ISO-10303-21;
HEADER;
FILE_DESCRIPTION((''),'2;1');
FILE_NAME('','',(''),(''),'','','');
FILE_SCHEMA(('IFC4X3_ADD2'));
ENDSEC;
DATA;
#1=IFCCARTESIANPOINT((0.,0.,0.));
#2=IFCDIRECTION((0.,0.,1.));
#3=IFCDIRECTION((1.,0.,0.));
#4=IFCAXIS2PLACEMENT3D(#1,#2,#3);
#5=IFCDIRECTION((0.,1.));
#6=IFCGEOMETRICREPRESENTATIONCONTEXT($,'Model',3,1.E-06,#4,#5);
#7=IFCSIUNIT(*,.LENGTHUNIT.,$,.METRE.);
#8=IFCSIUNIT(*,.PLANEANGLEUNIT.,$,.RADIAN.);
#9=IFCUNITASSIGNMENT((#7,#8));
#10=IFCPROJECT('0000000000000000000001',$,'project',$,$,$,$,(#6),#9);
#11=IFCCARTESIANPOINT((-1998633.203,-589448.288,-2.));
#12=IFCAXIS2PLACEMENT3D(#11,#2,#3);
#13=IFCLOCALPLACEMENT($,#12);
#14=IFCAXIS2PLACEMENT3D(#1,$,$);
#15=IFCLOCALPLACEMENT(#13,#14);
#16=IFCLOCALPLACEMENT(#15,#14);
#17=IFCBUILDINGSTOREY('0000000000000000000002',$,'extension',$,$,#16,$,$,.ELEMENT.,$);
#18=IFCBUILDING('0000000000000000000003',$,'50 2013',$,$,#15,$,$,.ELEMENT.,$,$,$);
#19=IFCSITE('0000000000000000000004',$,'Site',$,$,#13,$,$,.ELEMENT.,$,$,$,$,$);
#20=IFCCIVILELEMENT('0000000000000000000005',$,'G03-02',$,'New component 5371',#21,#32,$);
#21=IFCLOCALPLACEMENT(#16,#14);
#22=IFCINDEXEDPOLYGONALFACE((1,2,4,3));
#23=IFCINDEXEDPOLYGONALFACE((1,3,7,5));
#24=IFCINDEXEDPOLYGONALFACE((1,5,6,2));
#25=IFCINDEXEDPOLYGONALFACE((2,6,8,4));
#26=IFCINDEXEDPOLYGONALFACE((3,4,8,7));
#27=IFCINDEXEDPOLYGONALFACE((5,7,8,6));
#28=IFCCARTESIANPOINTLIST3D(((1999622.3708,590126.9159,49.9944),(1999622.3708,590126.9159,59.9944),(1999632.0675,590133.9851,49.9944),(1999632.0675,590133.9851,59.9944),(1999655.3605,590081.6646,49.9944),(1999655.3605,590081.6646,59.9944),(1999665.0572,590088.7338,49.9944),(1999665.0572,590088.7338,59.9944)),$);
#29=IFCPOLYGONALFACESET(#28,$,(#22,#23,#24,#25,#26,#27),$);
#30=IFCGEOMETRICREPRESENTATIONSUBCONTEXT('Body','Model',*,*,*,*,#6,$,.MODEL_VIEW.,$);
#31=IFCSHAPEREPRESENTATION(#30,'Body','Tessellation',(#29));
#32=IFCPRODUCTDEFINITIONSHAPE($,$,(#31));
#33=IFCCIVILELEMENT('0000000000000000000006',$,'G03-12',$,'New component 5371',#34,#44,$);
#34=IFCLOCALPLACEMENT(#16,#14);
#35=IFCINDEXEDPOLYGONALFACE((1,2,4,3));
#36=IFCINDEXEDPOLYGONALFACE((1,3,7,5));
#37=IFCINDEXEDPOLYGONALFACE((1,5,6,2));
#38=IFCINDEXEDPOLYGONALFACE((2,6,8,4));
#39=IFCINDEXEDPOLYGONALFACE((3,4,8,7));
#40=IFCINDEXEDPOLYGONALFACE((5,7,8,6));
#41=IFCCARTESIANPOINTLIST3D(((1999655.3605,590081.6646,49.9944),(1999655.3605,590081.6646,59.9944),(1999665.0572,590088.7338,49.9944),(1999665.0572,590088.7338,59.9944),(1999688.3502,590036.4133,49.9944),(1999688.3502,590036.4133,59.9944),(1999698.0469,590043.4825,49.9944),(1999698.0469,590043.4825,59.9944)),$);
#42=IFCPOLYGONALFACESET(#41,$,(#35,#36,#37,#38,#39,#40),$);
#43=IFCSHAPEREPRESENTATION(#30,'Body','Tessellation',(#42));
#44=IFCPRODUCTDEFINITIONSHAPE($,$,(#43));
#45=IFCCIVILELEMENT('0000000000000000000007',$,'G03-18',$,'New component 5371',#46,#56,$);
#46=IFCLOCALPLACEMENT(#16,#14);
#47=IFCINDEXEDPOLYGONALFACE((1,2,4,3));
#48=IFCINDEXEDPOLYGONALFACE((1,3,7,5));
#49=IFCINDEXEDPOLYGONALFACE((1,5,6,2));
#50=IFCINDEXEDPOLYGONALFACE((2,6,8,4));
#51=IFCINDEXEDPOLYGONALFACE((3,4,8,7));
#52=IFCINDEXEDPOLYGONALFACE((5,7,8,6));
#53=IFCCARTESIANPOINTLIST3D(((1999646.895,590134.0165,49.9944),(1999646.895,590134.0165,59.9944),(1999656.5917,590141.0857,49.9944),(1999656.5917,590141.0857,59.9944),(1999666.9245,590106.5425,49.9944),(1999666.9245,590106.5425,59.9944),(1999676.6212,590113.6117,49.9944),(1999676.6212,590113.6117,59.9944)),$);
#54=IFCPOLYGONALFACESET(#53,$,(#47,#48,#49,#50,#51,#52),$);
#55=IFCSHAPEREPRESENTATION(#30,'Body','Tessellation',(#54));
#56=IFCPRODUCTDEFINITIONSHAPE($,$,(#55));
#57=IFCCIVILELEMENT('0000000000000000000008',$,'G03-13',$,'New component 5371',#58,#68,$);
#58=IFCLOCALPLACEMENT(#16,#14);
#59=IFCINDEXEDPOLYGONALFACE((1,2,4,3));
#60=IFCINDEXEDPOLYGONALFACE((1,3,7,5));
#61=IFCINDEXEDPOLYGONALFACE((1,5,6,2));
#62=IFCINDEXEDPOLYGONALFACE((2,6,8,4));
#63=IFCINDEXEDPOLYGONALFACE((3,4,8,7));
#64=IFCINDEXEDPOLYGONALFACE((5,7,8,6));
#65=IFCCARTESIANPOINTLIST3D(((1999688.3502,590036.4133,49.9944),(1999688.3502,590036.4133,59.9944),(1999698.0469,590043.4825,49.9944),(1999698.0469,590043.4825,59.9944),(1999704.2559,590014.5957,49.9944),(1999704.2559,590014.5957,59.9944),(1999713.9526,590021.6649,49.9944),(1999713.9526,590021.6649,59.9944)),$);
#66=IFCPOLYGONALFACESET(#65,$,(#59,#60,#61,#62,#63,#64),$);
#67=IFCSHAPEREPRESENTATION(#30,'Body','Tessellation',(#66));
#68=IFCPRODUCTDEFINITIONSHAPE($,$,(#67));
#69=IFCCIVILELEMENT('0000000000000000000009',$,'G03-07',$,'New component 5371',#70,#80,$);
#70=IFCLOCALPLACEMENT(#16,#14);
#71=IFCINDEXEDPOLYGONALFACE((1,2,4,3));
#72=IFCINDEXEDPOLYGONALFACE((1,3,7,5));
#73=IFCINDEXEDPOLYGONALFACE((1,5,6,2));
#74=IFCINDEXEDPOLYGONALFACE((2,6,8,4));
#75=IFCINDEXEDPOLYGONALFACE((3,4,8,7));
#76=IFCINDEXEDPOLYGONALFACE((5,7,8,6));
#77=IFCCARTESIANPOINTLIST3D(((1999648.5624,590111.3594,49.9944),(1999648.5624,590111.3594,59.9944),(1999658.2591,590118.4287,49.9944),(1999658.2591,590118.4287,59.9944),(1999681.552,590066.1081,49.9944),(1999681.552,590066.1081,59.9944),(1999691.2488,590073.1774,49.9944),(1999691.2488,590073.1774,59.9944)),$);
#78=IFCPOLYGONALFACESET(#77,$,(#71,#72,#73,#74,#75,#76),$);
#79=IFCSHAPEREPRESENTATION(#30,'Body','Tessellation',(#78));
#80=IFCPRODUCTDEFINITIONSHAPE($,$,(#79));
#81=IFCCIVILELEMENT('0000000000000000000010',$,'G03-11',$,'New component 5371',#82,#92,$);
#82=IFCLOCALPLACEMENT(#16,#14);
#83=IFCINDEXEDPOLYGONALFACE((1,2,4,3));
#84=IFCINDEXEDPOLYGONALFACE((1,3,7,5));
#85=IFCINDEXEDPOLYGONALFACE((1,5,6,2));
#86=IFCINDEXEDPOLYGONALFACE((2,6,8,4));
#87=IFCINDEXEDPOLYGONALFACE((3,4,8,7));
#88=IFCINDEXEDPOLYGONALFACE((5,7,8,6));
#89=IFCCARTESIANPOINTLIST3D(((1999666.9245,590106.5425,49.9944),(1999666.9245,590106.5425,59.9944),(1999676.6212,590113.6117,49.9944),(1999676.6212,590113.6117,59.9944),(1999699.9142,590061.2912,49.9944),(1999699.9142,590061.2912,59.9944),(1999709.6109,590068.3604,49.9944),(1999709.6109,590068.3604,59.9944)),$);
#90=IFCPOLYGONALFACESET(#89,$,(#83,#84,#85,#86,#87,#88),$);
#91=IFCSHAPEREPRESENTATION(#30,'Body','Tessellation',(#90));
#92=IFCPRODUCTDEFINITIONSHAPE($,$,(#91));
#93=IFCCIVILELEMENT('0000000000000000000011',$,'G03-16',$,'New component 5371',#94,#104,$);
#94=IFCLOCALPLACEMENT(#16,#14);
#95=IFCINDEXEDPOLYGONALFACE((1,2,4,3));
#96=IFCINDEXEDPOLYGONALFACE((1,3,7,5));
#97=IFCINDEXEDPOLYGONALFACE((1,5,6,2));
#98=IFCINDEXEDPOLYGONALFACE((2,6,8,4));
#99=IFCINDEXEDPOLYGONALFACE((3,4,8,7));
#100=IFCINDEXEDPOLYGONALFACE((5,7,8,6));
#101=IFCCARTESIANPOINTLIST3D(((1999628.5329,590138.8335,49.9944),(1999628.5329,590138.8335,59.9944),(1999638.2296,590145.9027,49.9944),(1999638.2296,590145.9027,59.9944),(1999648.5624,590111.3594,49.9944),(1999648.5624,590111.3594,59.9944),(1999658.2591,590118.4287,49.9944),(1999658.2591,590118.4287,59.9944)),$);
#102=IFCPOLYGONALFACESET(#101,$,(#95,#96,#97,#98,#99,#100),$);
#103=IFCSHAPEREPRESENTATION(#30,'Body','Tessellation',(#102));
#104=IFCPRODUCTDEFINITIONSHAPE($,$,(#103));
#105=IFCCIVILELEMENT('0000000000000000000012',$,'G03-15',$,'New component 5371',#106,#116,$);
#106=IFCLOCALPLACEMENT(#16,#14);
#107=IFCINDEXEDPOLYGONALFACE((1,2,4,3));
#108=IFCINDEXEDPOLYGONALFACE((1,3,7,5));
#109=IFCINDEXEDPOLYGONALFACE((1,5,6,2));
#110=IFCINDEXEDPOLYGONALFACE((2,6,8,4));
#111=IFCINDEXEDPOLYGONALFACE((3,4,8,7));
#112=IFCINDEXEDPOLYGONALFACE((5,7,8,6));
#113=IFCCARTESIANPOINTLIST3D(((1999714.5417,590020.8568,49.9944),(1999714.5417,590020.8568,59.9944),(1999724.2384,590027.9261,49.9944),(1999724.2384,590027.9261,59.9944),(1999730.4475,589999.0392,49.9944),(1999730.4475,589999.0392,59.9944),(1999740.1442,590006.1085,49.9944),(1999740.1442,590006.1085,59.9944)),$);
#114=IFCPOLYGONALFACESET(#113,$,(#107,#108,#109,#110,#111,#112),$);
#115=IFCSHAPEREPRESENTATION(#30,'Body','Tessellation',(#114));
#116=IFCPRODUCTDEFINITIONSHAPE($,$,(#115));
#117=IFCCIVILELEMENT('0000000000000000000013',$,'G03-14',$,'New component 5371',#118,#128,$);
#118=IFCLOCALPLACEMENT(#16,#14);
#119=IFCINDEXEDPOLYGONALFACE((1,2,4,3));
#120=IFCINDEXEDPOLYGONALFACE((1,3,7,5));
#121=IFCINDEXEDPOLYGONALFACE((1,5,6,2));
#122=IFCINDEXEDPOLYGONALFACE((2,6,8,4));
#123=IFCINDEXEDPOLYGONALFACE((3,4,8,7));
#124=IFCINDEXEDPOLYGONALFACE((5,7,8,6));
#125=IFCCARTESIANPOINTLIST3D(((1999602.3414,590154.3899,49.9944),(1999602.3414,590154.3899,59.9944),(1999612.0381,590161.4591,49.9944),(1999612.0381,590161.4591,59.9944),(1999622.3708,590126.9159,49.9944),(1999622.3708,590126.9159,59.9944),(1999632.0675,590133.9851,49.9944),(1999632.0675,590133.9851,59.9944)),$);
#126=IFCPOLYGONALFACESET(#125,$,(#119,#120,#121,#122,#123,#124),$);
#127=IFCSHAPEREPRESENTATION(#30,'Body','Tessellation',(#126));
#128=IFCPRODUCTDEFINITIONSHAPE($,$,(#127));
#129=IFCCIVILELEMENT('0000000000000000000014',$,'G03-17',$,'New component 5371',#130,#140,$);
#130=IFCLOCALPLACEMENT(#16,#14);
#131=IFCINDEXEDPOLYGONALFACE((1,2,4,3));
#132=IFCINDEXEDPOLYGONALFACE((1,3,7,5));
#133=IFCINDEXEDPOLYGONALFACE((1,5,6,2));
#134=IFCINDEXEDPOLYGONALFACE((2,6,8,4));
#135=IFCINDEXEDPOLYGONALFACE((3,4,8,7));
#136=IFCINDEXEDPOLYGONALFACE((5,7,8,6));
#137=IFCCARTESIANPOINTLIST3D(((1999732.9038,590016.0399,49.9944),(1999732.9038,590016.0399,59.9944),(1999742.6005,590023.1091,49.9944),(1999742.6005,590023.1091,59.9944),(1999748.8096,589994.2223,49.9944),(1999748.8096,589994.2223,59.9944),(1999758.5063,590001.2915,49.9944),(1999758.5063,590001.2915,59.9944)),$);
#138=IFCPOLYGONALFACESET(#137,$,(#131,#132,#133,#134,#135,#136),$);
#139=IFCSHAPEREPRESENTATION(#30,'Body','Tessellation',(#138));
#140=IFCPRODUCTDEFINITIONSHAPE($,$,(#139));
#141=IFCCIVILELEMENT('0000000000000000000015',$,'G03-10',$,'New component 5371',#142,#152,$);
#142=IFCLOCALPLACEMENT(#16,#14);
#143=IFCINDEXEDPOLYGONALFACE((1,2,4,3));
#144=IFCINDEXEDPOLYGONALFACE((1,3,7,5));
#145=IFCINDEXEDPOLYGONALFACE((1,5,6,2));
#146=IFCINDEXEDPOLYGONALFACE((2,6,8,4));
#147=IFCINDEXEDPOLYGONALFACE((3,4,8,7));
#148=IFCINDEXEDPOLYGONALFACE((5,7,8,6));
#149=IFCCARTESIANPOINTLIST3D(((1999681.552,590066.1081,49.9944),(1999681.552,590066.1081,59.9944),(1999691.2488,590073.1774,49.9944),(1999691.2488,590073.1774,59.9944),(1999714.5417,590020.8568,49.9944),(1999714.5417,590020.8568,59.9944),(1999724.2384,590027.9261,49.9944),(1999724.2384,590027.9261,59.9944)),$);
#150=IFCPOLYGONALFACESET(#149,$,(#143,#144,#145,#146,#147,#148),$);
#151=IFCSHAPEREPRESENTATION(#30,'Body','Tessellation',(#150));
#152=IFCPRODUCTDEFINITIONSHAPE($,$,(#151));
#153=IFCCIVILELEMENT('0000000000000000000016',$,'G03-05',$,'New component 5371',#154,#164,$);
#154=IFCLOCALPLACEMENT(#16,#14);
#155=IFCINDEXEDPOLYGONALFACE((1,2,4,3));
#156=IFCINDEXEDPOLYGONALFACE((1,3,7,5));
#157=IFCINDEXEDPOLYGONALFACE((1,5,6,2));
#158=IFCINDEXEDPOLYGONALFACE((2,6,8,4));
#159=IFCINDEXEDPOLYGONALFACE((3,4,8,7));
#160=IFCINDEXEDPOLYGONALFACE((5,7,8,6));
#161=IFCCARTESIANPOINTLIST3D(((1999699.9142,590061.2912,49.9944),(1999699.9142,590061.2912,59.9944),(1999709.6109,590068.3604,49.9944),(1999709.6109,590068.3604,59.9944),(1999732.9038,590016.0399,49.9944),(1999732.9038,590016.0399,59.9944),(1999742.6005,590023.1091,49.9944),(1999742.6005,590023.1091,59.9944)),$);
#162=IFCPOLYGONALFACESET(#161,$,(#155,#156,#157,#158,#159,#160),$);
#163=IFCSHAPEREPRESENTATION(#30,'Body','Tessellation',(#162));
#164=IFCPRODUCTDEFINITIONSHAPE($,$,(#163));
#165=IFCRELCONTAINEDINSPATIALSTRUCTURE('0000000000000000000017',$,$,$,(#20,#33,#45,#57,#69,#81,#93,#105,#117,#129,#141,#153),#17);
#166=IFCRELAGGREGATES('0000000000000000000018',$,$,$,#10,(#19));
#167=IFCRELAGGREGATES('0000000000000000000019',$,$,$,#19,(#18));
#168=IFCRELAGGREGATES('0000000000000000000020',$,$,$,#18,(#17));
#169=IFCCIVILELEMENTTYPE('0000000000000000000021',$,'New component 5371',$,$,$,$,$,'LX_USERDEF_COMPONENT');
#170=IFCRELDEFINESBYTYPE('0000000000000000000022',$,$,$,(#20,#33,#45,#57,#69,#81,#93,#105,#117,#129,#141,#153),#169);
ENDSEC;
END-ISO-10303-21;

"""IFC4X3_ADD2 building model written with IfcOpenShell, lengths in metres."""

from ifc_helpers import new_model, si_unit, direction, frame, frame_2d, origin, origin_with_axes, place, context, subcontext, project, spatial, rectangle, extrude, type_object, element, save


model = new_model("IFC4X3_ADD2")

# Units and contexts
model_context = context("Model", 3, precision=1e-06, world=origin_with_axes(), true_north=direction((0.0, 1.0)))
body_context = subcontext(model_context, "Body", "Model", "MODEL_VIEW")
ifc_project = project(units=[si_unit("LENGTHUNIT", "METRE"), si_unit("PLANEANGLEUNIT", "RADIAN")], contexts=[model_context])

# Site, building, storey
site_placement = place(None, frame((-1998633.203, -589448.288, -2.0), z_axis=(0.0, 0.0, 1.0), x_axis=(1.0, 0.0, 0.0)))
site = spatial("IfcSite", under=ifc_project, at=site_placement, Name="Site", CompositionType="ELEMENT")
building_placement = place(site_placement, origin())
building = spatial("IfcBuilding", under=site, at=building_placement, Name="50 2013", CompositionType="ELEMENT")
storey_placement = place(building_placement, origin())
storey = spatial("IfcBuildingStorey", under=building, at=storey_placement, Name="extension", CompositionType="ELEMENT")

# Civil elements
civil_element_type = type_object("IfcCivilElementType", Name="New component 5371", ElementType="LX_USERDEF_COMPONENT")
for number, where, z_axis, x_axis, name in (
    (1, (1999655.3605, 590081.6646, 49.9944), (0.0, 0.0, 1.0), (0.808059, 0.589101, 0.0), "G03-02"),
    (2, (1999688.3502, 590036.4133, 49.9944), (0.0, 0.0, 1.0), (0.808059, 0.589101, 0.0), "G03-12"),
):
    element("IfcCivilElement", number, at=place(storey_placement, frame(where, z_axis=z_axis, x_axis=x_axis)), inside=storey, type_object=civil_element_type, Name=name, ObjectType="New component 5371", context=body_context, shape_type="SweptSolid", body=[
        extrude(rectangle(XDim=12.0, YDim=56.0, at=frame_2d((6.0, 28.0), x_axis=(1.0, 0.0))), origin_with_axes(), (0.0, 0.0, 1.0), 10.0),
    ])
civil_element_1_placement = place(storey_placement, frame((1999666.9245, 590106.5425, 49.9944), z_axis=(0.0, 0.0, 1.0), x_axis=(0.808059, 0.589101, 0.0)))
element("IfcCivilElement", 3, at=civil_element_1_placement, inside=storey, type_object=civil_element_type, Name="G03-18", ObjectType="New component 5371", context=body_context, shape_type="SweptSolid", body=[
    extrude(rectangle(XDim=12.0, YDim=34.0, at=frame_2d((6.0, 17.0), x_axis=(1.0, 0.0))), origin_with_axes(), (0.0, 0.0, 1.0), 10.0),
])
civil_element_2_placement = place(storey_placement, frame((1999704.2559, 590014.5957, 49.9944), z_axis=(0.0, 0.0, 1.0), x_axis=(0.808059, 0.589101, 0.0)))
element("IfcCivilElement", 4, at=civil_element_2_placement, inside=storey, type_object=civil_element_type, Name="G03-13", ObjectType="New component 5371", context=body_context, shape_type="SweptSolid", body=[
    extrude(rectangle(XDim=12.0, YDim=27.0, at=frame_2d((6.0, 13.5), x_axis=(1.0, 0.0))), origin_with_axes(), (0.0, 0.0, 1.0), 10.0),
])
for number, where, z_axis, x_axis, name in (
    (5, (1999681.552, 590066.1081, 49.9944), (0.0, 0.0, 1.0), (0.808059, 0.589101, 0.0), "G03-07"),
    (6, (1999699.9142, 590061.2912, 49.9944), (0.0, 0.0, 1.0), (0.808059, 0.589101, 0.0), "G03-11"),
):
    element("IfcCivilElement", number, at=place(storey_placement, frame(where, z_axis=z_axis, x_axis=x_axis)), inside=storey, type_object=civil_element_type, Name=name, ObjectType="New component 5371", context=body_context, shape_type="SweptSolid", body=[
        extrude(rectangle(XDim=12.0, YDim=56.0, at=frame_2d((6.0, 28.0), x_axis=(1.0, 0.0))), origin_with_axes(), (0.0, 0.0, 1.0), 10.0),
    ])
civil_element_3_placement = place(storey_placement, frame((1999648.5624, 590111.3594, 49.9944), z_axis=(0.0, 0.0, 1.0), x_axis=(0.808059, 0.589101, 0.0)))
element("IfcCivilElement", 7, at=civil_element_3_placement, inside=storey, type_object=civil_element_type, Name="G03-16", ObjectType="New component 5371", context=body_context, shape_type="SweptSolid", body=[
    extrude(rectangle(XDim=12.0, YDim=34.0, at=frame_2d((6.0, 17.0), x_axis=(1.0, 0.0))), origin_with_axes(), (0.0, 0.0, 1.0), 10.0),
])
civil_element_4_placement = place(storey_placement, frame((1999730.4475, 589999.0392, 49.9944), z_axis=(0.0, 0.0, 1.0), x_axis=(0.808059, 0.589101, 0.0)))
element("IfcCivilElement", 8, at=civil_element_4_placement, inside=storey, type_object=civil_element_type, Name="G03-15", ObjectType="New component 5371", context=body_context, shape_type="SweptSolid", body=[
    extrude(rectangle(XDim=12.0, YDim=27.0, at=frame_2d((6.0, 13.5), x_axis=(1.0, 0.0))), origin_with_axes(), (0.0, 0.0, 1.0), 10.0),
])
civil_element_5_placement = place(storey_placement, frame((1999622.3708, 590126.9159, 49.9944), z_axis=(0.0, 0.0, 1.0), x_axis=(0.808059, 0.589101, 0.0)))
element("IfcCivilElement", 9, at=civil_element_5_placement, inside=storey, type_object=civil_element_type, Name="G03-14", ObjectType="New component 5371", context=body_context, shape_type="SweptSolid", body=[
    extrude(rectangle(XDim=12.0, YDim=34.0, at=frame_2d((6.0, 17.0), x_axis=(1.0, 0.0))), origin_with_axes(), (0.0, 0.0, 1.0), 10.0),
])
civil_element_6_placement = place(storey_placement, frame((1999748.8096, 589994.2223, 49.9944), z_axis=(0.0, 0.0, 1.0), x_axis=(0.808059, 0.589101, 0.0)))
element("IfcCivilElement", 10, at=civil_element_6_placement, inside=storey, type_object=civil_element_type, Name="G03-17", ObjectType="New component 5371", context=body_context, shape_type="SweptSolid", body=[
    extrude(rectangle(XDim=12.0, YDim=27.0, at=frame_2d((6.0, 13.5), x_axis=(1.0, 0.0))), origin_with_axes(), (0.0, 0.0, 1.0), 10.0),
])
for number, where, z_axis, x_axis, name in (
    (11, (1999714.5417, 590020.8568, 49.9944), (0.0, 0.0, 1.0), (0.808059, 0.589101, 0.0), "G03-10"),
    (12, (1999732.9038, 590016.0399, 49.9944), (0.0, 0.0, 1.0), (0.808059, 0.589101, 0.0), "G03-05"),
):
    element("IfcCivilElement", number, at=place(storey_placement, frame(where, z_axis=z_axis, x_axis=x_axis)), inside=storey, type_object=civil_element_type, Name=name, ObjectType="New component 5371", context=body_context, shape_type="SweptSolid", body=[
        extrude(rectangle(XDim=12.0, YDim=56.0, at=frame_2d((6.0, 28.0), x_axis=(1.0, 0.0))), origin_with_axes(), (0.0, 0.0, 1.0), 10.0),
    ])

save(model, "model.ifc")
